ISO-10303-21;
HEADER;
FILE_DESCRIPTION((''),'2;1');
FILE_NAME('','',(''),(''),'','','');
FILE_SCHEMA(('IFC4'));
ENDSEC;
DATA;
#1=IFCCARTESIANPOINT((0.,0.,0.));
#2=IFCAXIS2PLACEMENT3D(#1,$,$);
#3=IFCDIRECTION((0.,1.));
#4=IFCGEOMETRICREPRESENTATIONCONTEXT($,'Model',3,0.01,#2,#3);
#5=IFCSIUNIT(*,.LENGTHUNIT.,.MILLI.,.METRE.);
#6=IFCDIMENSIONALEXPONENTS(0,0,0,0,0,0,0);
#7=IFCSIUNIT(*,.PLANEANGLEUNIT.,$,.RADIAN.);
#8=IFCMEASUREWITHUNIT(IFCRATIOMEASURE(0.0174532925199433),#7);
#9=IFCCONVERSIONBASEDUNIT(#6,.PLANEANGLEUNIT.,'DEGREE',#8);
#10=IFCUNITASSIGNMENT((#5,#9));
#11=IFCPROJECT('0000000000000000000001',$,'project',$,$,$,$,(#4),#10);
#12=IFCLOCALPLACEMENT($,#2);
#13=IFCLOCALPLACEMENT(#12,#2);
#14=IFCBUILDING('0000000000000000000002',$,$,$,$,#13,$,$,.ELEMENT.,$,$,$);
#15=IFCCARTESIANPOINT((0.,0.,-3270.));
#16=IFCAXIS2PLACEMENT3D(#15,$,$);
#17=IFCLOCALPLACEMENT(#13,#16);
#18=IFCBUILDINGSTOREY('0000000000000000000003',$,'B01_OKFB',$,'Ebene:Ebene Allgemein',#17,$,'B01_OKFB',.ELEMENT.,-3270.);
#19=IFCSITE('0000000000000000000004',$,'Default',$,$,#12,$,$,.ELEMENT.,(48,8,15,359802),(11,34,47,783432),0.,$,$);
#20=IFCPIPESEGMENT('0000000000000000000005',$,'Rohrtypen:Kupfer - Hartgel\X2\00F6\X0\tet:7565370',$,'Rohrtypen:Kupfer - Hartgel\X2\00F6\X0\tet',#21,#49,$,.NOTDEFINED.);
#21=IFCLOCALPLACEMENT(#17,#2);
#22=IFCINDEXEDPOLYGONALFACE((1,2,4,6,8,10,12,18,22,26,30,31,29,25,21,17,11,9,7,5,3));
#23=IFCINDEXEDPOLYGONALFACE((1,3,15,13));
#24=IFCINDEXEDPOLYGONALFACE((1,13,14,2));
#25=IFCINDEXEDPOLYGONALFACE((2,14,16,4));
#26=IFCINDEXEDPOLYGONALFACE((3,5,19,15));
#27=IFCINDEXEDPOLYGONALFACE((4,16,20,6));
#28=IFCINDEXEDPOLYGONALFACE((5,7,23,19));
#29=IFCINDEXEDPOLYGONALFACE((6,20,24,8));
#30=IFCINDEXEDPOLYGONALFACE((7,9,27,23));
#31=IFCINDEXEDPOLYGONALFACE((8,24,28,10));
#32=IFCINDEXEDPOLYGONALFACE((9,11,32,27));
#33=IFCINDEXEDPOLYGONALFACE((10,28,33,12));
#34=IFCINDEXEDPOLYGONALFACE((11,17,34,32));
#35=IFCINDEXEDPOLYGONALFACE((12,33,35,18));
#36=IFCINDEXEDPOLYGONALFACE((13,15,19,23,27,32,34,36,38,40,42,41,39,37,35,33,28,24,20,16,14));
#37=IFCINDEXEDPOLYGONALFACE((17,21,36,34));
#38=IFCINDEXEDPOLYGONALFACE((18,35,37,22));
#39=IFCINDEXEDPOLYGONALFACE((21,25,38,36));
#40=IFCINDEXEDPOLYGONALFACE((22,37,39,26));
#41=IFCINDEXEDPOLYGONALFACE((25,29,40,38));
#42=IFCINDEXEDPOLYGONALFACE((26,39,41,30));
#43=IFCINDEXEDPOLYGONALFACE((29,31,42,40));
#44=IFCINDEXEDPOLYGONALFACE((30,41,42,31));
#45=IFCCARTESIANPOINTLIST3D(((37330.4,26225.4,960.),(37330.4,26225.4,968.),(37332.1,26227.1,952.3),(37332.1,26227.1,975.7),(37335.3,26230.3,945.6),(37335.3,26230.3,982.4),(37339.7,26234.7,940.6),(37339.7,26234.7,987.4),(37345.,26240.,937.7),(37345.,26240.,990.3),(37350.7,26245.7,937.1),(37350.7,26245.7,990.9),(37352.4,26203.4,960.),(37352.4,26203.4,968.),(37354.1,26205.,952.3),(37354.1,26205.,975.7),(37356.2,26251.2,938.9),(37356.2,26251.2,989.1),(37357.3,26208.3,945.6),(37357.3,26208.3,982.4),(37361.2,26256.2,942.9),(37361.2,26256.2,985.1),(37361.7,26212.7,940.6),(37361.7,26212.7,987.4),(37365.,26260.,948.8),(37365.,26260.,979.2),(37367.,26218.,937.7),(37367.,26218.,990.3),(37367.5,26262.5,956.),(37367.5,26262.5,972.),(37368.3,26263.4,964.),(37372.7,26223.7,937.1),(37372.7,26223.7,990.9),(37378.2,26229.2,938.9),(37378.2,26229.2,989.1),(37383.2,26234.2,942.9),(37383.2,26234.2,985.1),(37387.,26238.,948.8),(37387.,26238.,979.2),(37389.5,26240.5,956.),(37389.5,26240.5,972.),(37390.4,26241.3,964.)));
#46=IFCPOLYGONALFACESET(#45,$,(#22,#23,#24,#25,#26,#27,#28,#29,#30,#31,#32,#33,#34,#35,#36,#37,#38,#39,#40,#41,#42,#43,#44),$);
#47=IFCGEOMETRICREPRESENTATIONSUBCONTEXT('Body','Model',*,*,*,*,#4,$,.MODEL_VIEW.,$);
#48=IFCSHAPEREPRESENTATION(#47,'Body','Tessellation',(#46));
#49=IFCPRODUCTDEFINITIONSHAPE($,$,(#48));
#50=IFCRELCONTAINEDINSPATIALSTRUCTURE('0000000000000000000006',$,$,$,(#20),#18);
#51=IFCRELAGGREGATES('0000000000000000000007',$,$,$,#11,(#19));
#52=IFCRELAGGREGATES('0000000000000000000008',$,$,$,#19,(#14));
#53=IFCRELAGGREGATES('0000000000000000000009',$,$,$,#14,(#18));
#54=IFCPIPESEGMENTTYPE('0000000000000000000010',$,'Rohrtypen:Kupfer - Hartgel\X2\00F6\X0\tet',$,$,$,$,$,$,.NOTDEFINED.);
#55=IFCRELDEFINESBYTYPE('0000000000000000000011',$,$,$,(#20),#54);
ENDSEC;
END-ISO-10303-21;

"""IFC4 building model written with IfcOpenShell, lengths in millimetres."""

from ifc_helpers import new_model, entity, si_unit, converted_unit, direction, frame, frame_2d, origin, place, context, subcontext, project, spatial, circle, extrude, type_object, element, save


model = new_model("IFC4")

# Units and contexts
model_context = context("Model", 3, precision=0.01, world=origin(), true_north=direction((0.0, 1.0)))
body_context = subcontext(model_context, "Body", "Model", "MODEL_VIEW")
ifc_project = project(units=[si_unit("LENGTHUNIT", "METRE", prefix="MILLI"), converted_unit("PLANEANGLEUNIT", "DEGREE", entity("IfcRatioMeasure", 0.0174532925199433), si_unit("PLANEANGLEUNIT", "RADIAN"), dimensions=[0, 0, 0, 0, 0, 0, 0])], contexts=[model_context])

# Site, building, storey
site_placement = place(None, origin())
site = spatial("IfcSite", under=ifc_project, at=site_placement, Name="Default", CompositionType="ELEMENT", RefLatitude=(48, 8, 15, 359802), RefLongitude=(11, 34, 47, 783432), RefElevation=0.0)
building_placement = place(site_placement, origin())
building = spatial("IfcBuilding", under=site, at=building_placement, CompositionType="ELEMENT")
storey_placement = place(building_placement, frame((0.0, 0.0, -3270.0)))
storey = spatial("IfcBuildingStorey", under=building, at=storey_placement, Name="B01_OKFB", ObjectType="Ebene:Ebene Allgemein", LongName="B01_OKFB", CompositionType="ELEMENT", Elevation=-3270.0)

# Pipe segment
pipe_segment_type = type_object("IfcPipeSegmentType", Name="Rohrtypen:Kupfer - Hartgelötet", PredefinedType="NOTDEFINED")
pipe_segment_1_placement = place(storey_placement, frame((37328.6, 26201.6, 935.4)))
element("IfcPipeSegment", 1, at=pipe_segment_1_placement, inside=storey, type_object=pipe_segment_type, Name="Rohrtypen:Kupfer - Hartgelötet:7565370", ObjectType="Rohrtypen:Kupfer - Hartgelötet", PredefinedType="NOTDEFINED", context=body_context, shape_type="SweptSolid", body=[
    extrude(circle(Radius=27.0, at=frame_2d((0.0, 0.0), x_axis=(1.0, 0.0))), frame((20.7, 42.7, 28.6), z_axis=(0.707107, -0.707107, 0.0), x_axis=(0.707107, 0.707107, 0.0)), (0.0, 0.0, 1.0), 31.1),
])

save(model, "model.ifc")
